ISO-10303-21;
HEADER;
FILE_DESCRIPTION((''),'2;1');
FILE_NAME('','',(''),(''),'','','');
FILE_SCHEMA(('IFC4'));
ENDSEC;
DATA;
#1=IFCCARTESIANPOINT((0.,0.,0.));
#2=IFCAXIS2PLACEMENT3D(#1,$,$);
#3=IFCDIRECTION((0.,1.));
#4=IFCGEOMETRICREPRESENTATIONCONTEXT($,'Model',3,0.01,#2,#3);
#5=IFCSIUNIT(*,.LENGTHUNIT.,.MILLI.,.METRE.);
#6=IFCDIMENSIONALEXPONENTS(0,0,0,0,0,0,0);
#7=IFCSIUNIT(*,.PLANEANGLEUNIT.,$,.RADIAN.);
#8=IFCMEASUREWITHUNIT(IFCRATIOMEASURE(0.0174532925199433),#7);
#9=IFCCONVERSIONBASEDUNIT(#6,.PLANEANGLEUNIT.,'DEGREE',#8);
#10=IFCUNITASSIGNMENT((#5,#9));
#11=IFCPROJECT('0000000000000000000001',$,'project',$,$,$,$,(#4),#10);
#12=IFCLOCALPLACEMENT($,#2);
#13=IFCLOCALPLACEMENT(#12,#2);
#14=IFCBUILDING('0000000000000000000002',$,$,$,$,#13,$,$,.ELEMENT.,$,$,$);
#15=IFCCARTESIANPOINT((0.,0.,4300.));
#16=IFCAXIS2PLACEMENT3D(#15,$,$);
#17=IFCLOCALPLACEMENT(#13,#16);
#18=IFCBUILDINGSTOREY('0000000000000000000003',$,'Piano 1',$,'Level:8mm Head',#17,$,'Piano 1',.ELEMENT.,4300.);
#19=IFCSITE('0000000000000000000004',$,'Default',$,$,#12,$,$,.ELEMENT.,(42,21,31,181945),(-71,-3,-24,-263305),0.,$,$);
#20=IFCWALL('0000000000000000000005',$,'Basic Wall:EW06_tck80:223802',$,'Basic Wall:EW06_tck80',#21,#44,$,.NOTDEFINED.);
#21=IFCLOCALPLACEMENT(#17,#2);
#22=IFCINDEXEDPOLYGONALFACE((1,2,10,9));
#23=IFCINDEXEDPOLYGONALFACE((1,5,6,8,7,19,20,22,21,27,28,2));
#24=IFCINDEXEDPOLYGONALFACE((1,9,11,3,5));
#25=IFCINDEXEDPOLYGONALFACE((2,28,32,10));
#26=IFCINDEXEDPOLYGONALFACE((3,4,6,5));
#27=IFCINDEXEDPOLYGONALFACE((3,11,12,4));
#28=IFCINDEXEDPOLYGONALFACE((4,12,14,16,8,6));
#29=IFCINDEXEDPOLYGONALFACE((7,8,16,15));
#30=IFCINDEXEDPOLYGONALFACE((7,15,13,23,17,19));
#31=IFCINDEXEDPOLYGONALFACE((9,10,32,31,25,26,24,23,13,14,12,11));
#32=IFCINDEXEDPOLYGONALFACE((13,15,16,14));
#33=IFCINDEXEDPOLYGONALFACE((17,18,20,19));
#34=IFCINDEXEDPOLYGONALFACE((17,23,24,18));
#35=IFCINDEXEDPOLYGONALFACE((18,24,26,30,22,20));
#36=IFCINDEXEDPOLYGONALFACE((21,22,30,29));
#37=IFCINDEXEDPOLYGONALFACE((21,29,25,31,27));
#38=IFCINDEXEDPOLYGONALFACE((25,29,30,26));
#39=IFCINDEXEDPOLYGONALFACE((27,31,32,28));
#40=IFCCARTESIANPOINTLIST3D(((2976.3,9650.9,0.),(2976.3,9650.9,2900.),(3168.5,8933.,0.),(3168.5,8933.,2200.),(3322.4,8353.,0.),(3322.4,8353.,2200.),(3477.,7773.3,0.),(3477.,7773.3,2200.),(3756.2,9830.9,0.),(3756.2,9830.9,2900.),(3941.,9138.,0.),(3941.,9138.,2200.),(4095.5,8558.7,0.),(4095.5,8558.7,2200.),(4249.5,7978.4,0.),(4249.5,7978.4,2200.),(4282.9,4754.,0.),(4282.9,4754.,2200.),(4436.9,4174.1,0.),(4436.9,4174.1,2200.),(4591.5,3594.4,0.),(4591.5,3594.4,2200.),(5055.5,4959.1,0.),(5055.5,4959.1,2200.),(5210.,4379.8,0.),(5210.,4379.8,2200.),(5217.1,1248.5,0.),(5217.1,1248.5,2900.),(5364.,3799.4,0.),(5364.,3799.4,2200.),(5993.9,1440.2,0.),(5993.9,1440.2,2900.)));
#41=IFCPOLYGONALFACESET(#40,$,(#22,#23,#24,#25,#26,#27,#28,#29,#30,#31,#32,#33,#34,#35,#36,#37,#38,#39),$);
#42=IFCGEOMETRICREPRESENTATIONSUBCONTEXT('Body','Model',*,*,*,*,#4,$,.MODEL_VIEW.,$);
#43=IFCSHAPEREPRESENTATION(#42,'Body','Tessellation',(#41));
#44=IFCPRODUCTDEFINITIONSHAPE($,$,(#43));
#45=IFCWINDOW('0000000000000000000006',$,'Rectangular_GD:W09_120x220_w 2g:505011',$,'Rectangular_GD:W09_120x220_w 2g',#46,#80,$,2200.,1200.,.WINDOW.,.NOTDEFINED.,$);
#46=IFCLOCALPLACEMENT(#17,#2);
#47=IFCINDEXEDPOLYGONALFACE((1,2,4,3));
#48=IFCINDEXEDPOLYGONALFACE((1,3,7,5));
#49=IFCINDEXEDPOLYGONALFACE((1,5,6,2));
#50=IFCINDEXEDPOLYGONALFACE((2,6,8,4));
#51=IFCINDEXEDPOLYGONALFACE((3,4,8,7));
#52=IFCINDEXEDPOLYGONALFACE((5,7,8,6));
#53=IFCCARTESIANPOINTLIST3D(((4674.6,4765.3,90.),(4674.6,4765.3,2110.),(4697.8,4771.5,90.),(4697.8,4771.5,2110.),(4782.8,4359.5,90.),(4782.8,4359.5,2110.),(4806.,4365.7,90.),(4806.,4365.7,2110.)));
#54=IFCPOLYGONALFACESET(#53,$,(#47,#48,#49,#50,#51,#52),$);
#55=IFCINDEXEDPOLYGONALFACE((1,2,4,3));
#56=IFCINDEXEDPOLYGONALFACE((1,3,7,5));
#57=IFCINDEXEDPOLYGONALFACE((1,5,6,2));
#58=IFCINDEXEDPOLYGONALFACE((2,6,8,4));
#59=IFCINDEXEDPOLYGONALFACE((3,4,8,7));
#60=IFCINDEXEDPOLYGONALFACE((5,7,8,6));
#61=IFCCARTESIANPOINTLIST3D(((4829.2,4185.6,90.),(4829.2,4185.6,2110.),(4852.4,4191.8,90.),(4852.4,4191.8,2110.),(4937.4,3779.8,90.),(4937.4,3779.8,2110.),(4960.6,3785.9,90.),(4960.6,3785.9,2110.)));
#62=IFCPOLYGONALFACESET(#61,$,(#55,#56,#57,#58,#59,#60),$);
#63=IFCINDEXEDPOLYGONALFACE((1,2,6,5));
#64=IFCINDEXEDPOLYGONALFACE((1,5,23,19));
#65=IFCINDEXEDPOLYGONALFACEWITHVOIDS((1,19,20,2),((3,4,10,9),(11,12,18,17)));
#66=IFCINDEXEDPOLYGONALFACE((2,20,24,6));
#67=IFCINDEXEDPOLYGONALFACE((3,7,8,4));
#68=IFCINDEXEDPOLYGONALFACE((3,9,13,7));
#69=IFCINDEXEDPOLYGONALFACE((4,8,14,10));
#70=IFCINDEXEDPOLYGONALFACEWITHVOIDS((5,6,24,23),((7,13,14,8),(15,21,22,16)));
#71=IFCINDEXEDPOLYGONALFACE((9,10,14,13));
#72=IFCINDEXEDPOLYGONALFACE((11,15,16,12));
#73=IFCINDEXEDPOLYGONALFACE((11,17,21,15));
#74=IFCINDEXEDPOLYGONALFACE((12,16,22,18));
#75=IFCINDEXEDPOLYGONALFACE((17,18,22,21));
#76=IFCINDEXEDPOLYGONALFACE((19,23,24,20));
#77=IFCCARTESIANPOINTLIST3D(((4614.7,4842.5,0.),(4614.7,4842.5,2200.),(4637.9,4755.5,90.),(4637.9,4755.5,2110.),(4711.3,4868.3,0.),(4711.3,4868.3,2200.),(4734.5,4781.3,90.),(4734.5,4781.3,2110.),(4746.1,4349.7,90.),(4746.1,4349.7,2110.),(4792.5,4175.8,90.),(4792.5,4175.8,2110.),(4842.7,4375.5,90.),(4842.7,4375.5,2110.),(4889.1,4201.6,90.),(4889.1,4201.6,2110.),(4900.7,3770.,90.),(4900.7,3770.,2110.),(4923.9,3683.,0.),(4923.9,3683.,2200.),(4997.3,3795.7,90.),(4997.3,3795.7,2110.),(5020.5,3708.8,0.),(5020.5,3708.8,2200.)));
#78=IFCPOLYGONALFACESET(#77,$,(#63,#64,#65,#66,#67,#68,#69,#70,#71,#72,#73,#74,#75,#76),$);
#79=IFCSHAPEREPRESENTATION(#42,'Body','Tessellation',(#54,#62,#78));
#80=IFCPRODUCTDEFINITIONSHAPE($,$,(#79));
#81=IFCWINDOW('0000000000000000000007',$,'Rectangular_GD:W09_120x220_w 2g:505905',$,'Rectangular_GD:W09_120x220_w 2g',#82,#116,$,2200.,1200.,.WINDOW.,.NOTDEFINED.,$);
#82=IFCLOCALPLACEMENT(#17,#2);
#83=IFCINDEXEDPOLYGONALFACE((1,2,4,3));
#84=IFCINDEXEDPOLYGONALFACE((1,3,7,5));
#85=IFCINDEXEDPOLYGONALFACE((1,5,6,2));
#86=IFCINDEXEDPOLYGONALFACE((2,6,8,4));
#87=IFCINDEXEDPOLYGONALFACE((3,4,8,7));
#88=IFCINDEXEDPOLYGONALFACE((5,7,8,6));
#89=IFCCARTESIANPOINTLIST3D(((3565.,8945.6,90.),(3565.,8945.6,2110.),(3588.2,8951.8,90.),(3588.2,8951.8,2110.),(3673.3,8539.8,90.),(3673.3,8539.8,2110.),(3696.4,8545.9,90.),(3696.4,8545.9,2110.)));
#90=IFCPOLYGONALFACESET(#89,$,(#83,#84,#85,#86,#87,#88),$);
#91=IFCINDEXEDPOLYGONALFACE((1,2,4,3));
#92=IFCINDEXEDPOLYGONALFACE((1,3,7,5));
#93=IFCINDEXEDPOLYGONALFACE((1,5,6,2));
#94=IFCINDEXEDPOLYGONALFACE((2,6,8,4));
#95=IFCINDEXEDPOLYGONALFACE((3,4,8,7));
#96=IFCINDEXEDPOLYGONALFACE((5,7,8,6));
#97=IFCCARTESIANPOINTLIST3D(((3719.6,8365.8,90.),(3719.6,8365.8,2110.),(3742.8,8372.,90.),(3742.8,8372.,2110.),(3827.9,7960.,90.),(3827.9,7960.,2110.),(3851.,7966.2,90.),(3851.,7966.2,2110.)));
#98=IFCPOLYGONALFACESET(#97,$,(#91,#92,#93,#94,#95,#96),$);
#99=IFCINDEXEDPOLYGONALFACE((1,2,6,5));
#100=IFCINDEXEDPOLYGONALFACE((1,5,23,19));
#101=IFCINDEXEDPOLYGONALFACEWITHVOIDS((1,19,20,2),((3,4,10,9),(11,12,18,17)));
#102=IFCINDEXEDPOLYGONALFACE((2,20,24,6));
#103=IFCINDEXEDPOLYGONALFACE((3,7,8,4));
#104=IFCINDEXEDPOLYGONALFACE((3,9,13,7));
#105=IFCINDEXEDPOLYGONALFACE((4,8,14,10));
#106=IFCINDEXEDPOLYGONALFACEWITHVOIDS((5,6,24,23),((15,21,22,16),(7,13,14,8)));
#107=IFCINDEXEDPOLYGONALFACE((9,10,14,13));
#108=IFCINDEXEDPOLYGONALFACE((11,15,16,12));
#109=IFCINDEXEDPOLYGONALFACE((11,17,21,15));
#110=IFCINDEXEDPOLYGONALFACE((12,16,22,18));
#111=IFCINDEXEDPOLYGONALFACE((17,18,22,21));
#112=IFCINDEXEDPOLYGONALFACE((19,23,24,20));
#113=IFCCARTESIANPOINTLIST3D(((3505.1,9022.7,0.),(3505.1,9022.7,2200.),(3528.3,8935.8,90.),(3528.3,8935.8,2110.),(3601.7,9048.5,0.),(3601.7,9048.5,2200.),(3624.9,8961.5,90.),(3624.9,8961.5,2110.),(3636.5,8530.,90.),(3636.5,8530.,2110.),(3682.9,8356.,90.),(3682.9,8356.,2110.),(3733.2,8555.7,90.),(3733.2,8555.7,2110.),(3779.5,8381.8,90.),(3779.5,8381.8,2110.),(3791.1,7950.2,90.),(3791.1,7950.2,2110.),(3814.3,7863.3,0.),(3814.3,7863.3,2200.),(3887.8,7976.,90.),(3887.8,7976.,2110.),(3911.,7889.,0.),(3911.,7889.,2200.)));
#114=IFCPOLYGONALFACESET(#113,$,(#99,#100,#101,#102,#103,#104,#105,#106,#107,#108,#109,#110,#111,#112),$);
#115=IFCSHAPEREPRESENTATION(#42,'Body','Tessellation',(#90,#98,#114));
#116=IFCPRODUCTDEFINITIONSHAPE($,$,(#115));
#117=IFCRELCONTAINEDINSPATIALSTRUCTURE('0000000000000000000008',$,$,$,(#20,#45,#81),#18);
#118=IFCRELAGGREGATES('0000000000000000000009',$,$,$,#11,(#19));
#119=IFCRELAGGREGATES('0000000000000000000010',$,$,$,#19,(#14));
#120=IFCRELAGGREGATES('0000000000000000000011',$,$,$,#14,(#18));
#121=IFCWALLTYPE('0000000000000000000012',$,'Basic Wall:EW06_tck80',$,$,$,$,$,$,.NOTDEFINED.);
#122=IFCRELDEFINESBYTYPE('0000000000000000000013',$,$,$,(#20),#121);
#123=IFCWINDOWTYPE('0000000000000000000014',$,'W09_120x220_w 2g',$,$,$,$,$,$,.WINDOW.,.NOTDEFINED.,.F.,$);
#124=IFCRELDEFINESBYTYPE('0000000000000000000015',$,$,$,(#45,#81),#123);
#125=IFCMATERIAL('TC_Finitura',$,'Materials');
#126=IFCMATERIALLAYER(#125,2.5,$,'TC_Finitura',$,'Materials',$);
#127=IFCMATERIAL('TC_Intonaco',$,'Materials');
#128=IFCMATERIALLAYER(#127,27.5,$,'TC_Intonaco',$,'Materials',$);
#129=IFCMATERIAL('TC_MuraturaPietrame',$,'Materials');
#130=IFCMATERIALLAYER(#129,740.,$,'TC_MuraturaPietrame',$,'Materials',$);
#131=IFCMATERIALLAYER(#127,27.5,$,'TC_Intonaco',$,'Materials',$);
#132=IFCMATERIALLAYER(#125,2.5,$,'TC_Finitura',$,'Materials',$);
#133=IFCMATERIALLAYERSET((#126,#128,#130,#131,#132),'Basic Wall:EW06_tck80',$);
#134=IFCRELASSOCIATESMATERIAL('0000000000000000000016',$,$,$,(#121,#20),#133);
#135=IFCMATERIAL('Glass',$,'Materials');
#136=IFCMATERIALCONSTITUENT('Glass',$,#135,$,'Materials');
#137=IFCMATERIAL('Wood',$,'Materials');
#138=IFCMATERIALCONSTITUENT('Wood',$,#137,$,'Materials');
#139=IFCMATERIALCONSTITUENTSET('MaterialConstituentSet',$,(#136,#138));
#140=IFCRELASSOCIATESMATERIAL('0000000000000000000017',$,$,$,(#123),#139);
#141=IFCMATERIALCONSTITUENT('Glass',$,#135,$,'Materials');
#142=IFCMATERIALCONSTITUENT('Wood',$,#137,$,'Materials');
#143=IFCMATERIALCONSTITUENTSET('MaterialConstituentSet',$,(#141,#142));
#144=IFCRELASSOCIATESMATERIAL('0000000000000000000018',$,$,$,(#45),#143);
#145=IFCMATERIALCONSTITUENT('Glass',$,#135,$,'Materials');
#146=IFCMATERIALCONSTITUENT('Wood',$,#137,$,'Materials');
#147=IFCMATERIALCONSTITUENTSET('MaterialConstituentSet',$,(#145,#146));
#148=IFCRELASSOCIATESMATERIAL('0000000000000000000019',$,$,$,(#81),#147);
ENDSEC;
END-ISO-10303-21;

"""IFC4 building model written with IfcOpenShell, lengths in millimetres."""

from ifc_helpers import new_model, entity, si_unit, converted_unit, direction, frame, frame_2d, origin, origin_2d_with_axis, place, context, subcontext, project, spatial, polyline, rectangle, outline, extrude, clip, bounded_halfspace, source, transform, mapped, material, layer, layer_set, layer_usage, constituent, constituent_set, type_object, type_shapes, element, fill, save


model = new_model("IFC4")

# Units and contexts
model_context = context("Model", 3, precision=0.01, world=origin(), true_north=direction((0.0, 1.0)))
body_context = subcontext(model_context, "Body", "Model", "MODEL_VIEW")
ifc_project = project(units=[si_unit("LENGTHUNIT", "METRE", prefix="MILLI"), converted_unit("PLANEANGLEUNIT", "DEGREE", entity("IfcRatioMeasure", 0.0174532925199433), si_unit("PLANEANGLEUNIT", "RADIAN"), dimensions=[0, 0, 0, 0, 0, 0, 0])], contexts=[model_context])

# Site, building, storey
site_placement = place(None, origin())
site = spatial("IfcSite", under=ifc_project, at=site_placement, Name="Default", CompositionType="ELEMENT", RefLatitude=(42, 21, 31, 181945), RefLongitude=(-71, -3, -24, -263305), RefElevation=0.0)
building_placement = place(site_placement, origin())
building = spatial("IfcBuilding", under=site, at=building_placement, CompositionType="ELEMENT")
storey_placement = place(building_placement, frame((0.0, 0.0, 4300.0)))
storey = spatial("IfcBuildingStorey", under=building, at=storey_placement, Name="Piano 1", ObjectType="Level:8mm Head", LongName="Piano 1", CompositionType="ELEMENT", Elevation=4300.0)

# Shared definitions
ifc_material_1 = material(Name="TC_Finitura", Category="Materials")
ifc_layer_1 = layer(ifc_material_1, 2.5, Name="TC_Finitura", Category="Materials")
ifc_material_2 = material(Name="TC_Intonaco", Category="Materials")
ifc_layer_2 = layer(ifc_material_2, 27.5, Name="TC_Intonaco", Category="Materials")
ifc_material_3 = material(Name="TC_MuraturaPietrame", Category="Materials")
ifc_layer_3 = layer(ifc_material_3, 740.0, Name="TC_MuraturaPietrame", Category="Materials")
ifc_layer_4 = layer(ifc_material_2, 27.5, Name="TC_Intonaco", Category="Materials")
ifc_layer_5 = layer(ifc_material_1, 2.5, Name="TC_Finitura", Category="Materials")
ifc_layer_set_1 = layer_set([ifc_layer_1, ifc_layer_2, ifc_layer_3, ifc_layer_4, ifc_layer_5], Name="Basic Wall:EW06_tck80")
wall_type_1 = type_object("IfcWallType", Name="Basic Wall:EW06_tck80", PredefinedType="NOTDEFINED", material=ifc_layer_set_1)
ifc_material_4 = material(Name="Glass", Category="Materials")
ifc_material_5 = material(Name="Wood", Category="Materials")
ifc_constituent_1 = constituent(ifc_material_4, Name="Glass", Category="Materials")
ifc_constituent_2 = constituent(ifc_material_5, Name="Wood", Category="Materials")
ifc_constituent_set_1 = constituent_set(constituents=[ifc_constituent_1, ifc_constituent_2], Name="MaterialConstituentSet")
window_type_1 = type_object("IfcWindowType", Name="W09_120x220_w 2g", ParameterTakesPrecedence=False, PartitioningType="NOTDEFINED", PredefinedType="WINDOW", material=ifc_constituent_set_1)
shared_shape_1 = source(origin(), body_context, "Body", "SweptSolid", [
    extrude(rectangle(XDim=24.0, YDim=420.0, at=frame_2d((0.0, 0.0), x_axis=(1.0, 0.0))), frame((300.0, 400.0, 90.0), z_axis=(0.0, 0.0, 1.0), x_axis=(0.0, 1.0, 0.0)), (0.0, 0.0, 1.0), 2020.0),
    extrude(rectangle(XDim=24.0, YDim=420.0, at=origin_2d_with_axis()), frame((900.0, 400.0, 90.0), z_axis=(0.0, 0.0, 1.0), x_axis=(0.0, 1.0, 0.0)), (0.0, 0.0, 1.0), 2020.0),
    extrude(outline(polyline([(-600.0, -1100.0), (600.0, -1100.0), (600.0, 1100.0), (-600.0, 1100.0), (-600.0, -1100.0)]), holes=[polyline([(-510.0, 1010.0), (-90.0, 1010.0), (-90.0, -1010.0), (-510.0, -1010.0), (-510.0, 1010.0)]), polyline([(90.0, -1010.0), (90.0, 1010.0), (510.0, 1010.0), (510.0, -1010.0), (90.0, -1010.0)])]), frame((600.0, 350.0, 1100.0), z_axis=(0.0, 1.0, 0.0), x_axis=(1.0, 0.0, 0.0)), (0.0, 0.0, 1.0), 100.0),
])
type_shapes(window_type_1, [shared_shape_1])

# Wall, openings, windows
ifc_layer_usage_1 = layer_usage(ifc_layer_set_1, "AXIS2", "NEGATIVE", 400.0)
wall_1_placement = place(storey_placement, frame((3362.8, 9753.9, 0.0), z_axis=(0.0, 0.0, 1.0), x_axis=(0.257683, -0.966229, 0.0)))
wall_1 = element("IfcWall", 1, at=wall_1_placement, inside=storey, type_object=wall_type_1, material=ifc_layer_usage_1, Name="Basic Wall:EW06_tck80:223802", ObjectType="Basic Wall:EW06_tck80", PredefinedType="NOTDEFINED", context=body_context, shape_type="Clipping", body=[
    clip(extrude(outline(polyline([(0.0, -400.0), (8696.0, -400.0), (8711.0, 400.0), (7860.8, 400.0), (4146.8, 400.0), (3446.4, 400.0), (27.0, 400.0), (0.0, -400.0)])), origin(), (0.0, 0.0, 1.0), 2900.0), bounded_halfspace(frame((0.0, -400.0, 2900.0), z_axis=(0.0, 0.0, -1.0), x_axis=(-0.013567, 0.999908, 0.0)), True, frame((0.0, -400.0, 2900.0)), polyline([(0.0, 0.0), (8696.0, 0.0), (8711.0, 800.0), (7860.8, 800.0), (4146.8, 800.0), (3446.4, 800.0), (27.0, 800.0), (0.0, 0.0)]))),
])
opening_1_placement = place(wall_1_placement, frame((5068.2, -399.3, 0.0)))
opening_1 = element("IfcOpeningElement", 2, at=opening_1_placement, cuts=wall_1, ObjectType="Opening", PredefinedType="OPENING", context=body_context, shape_type="SweptSolid", body=[
    extrude(rectangle(XDim=2200.0, YDim=1200.0, at=frame_2d((1100.0, 600.0), x_axis=(-1.0, 0.0))), frame((0.0, 0.0, 0.0), z_axis=(0.001176, 0.999999, 0.0), x_axis=(0.0, 0.0, 1.0)), (0.0, 0.0, 1.0), 800.0),
])
opening_2_placement = place(wall_1_placement, frame((743.2, -399.3, 0.0)))
opening_2 = element("IfcOpeningElement", 3, at=opening_2_placement, cuts=wall_1, ObjectType="Opening", PredefinedType="OPENING", context=body_context, shape_type="SweptSolid", body=[
    extrude(rectangle(XDim=2200.0, YDim=1200.0, at=frame_2d((1100.0, 600.0), x_axis=(-1.0, 0.0))), frame((0.0, 0.0, 0.0), z_axis=(0.001176, 0.999999, 0.0), x_axis=(0.0, 0.0, 1.0)), (0.0, 0.0, 1.0), 800.0),
])
ifc_constituent_3 = constituent(ifc_material_4, Name="Glass", Category="Materials")
ifc_constituent_4 = constituent(ifc_material_5, Name="Wood", Category="Materials")
ifc_constituent_set_2 = constituent_set(constituents=[ifc_constituent_3, ifc_constituent_4], Name="MaterialConstituentSet")
window_1_placement = place(opening_1_placement, frame((0.0, -6.7, 0.0)))
window_1 = element("IfcWindow", 4, at=window_1_placement, inside=storey, type_object=window_type_1, material=ifc_constituent_set_2, Name="Rectangular_GD:W09_120x220_w 2g:505011", ObjectType="Rectangular_GD:W09_120x220_w 2g", OverallHeight=2200.0, OverallWidth=1200.0, PartitioningType="NOTDEFINED", PredefinedType="WINDOW", context=body_context, shape_type="MappedRepresentation", body=[
    mapped(shared_shape_1, transform((0.0, 0.0, 0.0), scale=1.0)),
])
fill(opening_1, window_1)
ifc_constituent_5 = constituent(ifc_material_4, Name="Glass", Category="Materials")
ifc_constituent_6 = constituent(ifc_material_5, Name="Wood", Category="Materials")
ifc_constituent_set_3 = constituent_set(constituents=[ifc_constituent_5, ifc_constituent_6], Name="MaterialConstituentSet")
window_2_placement = place(opening_2_placement, frame((0.0, -1.6, 0.0)))
window_2 = element("IfcWindow", 5, at=window_2_placement, inside=storey, type_object=window_type_1, material=ifc_constituent_set_3, Name="Rectangular_GD:W09_120x220_w 2g:505905", ObjectType="Rectangular_GD:W09_120x220_w 2g", OverallHeight=2200.0, OverallWidth=1200.0, PartitioningType="NOTDEFINED", PredefinedType="WINDOW", context=body_context, shape_type="MappedRepresentation", body=[
    mapped(shared_shape_1, transform((0.0, 0.0, 0.0), scale=1.0)),
])
fill(opening_2, window_2)

save(model, "model.ifc")
